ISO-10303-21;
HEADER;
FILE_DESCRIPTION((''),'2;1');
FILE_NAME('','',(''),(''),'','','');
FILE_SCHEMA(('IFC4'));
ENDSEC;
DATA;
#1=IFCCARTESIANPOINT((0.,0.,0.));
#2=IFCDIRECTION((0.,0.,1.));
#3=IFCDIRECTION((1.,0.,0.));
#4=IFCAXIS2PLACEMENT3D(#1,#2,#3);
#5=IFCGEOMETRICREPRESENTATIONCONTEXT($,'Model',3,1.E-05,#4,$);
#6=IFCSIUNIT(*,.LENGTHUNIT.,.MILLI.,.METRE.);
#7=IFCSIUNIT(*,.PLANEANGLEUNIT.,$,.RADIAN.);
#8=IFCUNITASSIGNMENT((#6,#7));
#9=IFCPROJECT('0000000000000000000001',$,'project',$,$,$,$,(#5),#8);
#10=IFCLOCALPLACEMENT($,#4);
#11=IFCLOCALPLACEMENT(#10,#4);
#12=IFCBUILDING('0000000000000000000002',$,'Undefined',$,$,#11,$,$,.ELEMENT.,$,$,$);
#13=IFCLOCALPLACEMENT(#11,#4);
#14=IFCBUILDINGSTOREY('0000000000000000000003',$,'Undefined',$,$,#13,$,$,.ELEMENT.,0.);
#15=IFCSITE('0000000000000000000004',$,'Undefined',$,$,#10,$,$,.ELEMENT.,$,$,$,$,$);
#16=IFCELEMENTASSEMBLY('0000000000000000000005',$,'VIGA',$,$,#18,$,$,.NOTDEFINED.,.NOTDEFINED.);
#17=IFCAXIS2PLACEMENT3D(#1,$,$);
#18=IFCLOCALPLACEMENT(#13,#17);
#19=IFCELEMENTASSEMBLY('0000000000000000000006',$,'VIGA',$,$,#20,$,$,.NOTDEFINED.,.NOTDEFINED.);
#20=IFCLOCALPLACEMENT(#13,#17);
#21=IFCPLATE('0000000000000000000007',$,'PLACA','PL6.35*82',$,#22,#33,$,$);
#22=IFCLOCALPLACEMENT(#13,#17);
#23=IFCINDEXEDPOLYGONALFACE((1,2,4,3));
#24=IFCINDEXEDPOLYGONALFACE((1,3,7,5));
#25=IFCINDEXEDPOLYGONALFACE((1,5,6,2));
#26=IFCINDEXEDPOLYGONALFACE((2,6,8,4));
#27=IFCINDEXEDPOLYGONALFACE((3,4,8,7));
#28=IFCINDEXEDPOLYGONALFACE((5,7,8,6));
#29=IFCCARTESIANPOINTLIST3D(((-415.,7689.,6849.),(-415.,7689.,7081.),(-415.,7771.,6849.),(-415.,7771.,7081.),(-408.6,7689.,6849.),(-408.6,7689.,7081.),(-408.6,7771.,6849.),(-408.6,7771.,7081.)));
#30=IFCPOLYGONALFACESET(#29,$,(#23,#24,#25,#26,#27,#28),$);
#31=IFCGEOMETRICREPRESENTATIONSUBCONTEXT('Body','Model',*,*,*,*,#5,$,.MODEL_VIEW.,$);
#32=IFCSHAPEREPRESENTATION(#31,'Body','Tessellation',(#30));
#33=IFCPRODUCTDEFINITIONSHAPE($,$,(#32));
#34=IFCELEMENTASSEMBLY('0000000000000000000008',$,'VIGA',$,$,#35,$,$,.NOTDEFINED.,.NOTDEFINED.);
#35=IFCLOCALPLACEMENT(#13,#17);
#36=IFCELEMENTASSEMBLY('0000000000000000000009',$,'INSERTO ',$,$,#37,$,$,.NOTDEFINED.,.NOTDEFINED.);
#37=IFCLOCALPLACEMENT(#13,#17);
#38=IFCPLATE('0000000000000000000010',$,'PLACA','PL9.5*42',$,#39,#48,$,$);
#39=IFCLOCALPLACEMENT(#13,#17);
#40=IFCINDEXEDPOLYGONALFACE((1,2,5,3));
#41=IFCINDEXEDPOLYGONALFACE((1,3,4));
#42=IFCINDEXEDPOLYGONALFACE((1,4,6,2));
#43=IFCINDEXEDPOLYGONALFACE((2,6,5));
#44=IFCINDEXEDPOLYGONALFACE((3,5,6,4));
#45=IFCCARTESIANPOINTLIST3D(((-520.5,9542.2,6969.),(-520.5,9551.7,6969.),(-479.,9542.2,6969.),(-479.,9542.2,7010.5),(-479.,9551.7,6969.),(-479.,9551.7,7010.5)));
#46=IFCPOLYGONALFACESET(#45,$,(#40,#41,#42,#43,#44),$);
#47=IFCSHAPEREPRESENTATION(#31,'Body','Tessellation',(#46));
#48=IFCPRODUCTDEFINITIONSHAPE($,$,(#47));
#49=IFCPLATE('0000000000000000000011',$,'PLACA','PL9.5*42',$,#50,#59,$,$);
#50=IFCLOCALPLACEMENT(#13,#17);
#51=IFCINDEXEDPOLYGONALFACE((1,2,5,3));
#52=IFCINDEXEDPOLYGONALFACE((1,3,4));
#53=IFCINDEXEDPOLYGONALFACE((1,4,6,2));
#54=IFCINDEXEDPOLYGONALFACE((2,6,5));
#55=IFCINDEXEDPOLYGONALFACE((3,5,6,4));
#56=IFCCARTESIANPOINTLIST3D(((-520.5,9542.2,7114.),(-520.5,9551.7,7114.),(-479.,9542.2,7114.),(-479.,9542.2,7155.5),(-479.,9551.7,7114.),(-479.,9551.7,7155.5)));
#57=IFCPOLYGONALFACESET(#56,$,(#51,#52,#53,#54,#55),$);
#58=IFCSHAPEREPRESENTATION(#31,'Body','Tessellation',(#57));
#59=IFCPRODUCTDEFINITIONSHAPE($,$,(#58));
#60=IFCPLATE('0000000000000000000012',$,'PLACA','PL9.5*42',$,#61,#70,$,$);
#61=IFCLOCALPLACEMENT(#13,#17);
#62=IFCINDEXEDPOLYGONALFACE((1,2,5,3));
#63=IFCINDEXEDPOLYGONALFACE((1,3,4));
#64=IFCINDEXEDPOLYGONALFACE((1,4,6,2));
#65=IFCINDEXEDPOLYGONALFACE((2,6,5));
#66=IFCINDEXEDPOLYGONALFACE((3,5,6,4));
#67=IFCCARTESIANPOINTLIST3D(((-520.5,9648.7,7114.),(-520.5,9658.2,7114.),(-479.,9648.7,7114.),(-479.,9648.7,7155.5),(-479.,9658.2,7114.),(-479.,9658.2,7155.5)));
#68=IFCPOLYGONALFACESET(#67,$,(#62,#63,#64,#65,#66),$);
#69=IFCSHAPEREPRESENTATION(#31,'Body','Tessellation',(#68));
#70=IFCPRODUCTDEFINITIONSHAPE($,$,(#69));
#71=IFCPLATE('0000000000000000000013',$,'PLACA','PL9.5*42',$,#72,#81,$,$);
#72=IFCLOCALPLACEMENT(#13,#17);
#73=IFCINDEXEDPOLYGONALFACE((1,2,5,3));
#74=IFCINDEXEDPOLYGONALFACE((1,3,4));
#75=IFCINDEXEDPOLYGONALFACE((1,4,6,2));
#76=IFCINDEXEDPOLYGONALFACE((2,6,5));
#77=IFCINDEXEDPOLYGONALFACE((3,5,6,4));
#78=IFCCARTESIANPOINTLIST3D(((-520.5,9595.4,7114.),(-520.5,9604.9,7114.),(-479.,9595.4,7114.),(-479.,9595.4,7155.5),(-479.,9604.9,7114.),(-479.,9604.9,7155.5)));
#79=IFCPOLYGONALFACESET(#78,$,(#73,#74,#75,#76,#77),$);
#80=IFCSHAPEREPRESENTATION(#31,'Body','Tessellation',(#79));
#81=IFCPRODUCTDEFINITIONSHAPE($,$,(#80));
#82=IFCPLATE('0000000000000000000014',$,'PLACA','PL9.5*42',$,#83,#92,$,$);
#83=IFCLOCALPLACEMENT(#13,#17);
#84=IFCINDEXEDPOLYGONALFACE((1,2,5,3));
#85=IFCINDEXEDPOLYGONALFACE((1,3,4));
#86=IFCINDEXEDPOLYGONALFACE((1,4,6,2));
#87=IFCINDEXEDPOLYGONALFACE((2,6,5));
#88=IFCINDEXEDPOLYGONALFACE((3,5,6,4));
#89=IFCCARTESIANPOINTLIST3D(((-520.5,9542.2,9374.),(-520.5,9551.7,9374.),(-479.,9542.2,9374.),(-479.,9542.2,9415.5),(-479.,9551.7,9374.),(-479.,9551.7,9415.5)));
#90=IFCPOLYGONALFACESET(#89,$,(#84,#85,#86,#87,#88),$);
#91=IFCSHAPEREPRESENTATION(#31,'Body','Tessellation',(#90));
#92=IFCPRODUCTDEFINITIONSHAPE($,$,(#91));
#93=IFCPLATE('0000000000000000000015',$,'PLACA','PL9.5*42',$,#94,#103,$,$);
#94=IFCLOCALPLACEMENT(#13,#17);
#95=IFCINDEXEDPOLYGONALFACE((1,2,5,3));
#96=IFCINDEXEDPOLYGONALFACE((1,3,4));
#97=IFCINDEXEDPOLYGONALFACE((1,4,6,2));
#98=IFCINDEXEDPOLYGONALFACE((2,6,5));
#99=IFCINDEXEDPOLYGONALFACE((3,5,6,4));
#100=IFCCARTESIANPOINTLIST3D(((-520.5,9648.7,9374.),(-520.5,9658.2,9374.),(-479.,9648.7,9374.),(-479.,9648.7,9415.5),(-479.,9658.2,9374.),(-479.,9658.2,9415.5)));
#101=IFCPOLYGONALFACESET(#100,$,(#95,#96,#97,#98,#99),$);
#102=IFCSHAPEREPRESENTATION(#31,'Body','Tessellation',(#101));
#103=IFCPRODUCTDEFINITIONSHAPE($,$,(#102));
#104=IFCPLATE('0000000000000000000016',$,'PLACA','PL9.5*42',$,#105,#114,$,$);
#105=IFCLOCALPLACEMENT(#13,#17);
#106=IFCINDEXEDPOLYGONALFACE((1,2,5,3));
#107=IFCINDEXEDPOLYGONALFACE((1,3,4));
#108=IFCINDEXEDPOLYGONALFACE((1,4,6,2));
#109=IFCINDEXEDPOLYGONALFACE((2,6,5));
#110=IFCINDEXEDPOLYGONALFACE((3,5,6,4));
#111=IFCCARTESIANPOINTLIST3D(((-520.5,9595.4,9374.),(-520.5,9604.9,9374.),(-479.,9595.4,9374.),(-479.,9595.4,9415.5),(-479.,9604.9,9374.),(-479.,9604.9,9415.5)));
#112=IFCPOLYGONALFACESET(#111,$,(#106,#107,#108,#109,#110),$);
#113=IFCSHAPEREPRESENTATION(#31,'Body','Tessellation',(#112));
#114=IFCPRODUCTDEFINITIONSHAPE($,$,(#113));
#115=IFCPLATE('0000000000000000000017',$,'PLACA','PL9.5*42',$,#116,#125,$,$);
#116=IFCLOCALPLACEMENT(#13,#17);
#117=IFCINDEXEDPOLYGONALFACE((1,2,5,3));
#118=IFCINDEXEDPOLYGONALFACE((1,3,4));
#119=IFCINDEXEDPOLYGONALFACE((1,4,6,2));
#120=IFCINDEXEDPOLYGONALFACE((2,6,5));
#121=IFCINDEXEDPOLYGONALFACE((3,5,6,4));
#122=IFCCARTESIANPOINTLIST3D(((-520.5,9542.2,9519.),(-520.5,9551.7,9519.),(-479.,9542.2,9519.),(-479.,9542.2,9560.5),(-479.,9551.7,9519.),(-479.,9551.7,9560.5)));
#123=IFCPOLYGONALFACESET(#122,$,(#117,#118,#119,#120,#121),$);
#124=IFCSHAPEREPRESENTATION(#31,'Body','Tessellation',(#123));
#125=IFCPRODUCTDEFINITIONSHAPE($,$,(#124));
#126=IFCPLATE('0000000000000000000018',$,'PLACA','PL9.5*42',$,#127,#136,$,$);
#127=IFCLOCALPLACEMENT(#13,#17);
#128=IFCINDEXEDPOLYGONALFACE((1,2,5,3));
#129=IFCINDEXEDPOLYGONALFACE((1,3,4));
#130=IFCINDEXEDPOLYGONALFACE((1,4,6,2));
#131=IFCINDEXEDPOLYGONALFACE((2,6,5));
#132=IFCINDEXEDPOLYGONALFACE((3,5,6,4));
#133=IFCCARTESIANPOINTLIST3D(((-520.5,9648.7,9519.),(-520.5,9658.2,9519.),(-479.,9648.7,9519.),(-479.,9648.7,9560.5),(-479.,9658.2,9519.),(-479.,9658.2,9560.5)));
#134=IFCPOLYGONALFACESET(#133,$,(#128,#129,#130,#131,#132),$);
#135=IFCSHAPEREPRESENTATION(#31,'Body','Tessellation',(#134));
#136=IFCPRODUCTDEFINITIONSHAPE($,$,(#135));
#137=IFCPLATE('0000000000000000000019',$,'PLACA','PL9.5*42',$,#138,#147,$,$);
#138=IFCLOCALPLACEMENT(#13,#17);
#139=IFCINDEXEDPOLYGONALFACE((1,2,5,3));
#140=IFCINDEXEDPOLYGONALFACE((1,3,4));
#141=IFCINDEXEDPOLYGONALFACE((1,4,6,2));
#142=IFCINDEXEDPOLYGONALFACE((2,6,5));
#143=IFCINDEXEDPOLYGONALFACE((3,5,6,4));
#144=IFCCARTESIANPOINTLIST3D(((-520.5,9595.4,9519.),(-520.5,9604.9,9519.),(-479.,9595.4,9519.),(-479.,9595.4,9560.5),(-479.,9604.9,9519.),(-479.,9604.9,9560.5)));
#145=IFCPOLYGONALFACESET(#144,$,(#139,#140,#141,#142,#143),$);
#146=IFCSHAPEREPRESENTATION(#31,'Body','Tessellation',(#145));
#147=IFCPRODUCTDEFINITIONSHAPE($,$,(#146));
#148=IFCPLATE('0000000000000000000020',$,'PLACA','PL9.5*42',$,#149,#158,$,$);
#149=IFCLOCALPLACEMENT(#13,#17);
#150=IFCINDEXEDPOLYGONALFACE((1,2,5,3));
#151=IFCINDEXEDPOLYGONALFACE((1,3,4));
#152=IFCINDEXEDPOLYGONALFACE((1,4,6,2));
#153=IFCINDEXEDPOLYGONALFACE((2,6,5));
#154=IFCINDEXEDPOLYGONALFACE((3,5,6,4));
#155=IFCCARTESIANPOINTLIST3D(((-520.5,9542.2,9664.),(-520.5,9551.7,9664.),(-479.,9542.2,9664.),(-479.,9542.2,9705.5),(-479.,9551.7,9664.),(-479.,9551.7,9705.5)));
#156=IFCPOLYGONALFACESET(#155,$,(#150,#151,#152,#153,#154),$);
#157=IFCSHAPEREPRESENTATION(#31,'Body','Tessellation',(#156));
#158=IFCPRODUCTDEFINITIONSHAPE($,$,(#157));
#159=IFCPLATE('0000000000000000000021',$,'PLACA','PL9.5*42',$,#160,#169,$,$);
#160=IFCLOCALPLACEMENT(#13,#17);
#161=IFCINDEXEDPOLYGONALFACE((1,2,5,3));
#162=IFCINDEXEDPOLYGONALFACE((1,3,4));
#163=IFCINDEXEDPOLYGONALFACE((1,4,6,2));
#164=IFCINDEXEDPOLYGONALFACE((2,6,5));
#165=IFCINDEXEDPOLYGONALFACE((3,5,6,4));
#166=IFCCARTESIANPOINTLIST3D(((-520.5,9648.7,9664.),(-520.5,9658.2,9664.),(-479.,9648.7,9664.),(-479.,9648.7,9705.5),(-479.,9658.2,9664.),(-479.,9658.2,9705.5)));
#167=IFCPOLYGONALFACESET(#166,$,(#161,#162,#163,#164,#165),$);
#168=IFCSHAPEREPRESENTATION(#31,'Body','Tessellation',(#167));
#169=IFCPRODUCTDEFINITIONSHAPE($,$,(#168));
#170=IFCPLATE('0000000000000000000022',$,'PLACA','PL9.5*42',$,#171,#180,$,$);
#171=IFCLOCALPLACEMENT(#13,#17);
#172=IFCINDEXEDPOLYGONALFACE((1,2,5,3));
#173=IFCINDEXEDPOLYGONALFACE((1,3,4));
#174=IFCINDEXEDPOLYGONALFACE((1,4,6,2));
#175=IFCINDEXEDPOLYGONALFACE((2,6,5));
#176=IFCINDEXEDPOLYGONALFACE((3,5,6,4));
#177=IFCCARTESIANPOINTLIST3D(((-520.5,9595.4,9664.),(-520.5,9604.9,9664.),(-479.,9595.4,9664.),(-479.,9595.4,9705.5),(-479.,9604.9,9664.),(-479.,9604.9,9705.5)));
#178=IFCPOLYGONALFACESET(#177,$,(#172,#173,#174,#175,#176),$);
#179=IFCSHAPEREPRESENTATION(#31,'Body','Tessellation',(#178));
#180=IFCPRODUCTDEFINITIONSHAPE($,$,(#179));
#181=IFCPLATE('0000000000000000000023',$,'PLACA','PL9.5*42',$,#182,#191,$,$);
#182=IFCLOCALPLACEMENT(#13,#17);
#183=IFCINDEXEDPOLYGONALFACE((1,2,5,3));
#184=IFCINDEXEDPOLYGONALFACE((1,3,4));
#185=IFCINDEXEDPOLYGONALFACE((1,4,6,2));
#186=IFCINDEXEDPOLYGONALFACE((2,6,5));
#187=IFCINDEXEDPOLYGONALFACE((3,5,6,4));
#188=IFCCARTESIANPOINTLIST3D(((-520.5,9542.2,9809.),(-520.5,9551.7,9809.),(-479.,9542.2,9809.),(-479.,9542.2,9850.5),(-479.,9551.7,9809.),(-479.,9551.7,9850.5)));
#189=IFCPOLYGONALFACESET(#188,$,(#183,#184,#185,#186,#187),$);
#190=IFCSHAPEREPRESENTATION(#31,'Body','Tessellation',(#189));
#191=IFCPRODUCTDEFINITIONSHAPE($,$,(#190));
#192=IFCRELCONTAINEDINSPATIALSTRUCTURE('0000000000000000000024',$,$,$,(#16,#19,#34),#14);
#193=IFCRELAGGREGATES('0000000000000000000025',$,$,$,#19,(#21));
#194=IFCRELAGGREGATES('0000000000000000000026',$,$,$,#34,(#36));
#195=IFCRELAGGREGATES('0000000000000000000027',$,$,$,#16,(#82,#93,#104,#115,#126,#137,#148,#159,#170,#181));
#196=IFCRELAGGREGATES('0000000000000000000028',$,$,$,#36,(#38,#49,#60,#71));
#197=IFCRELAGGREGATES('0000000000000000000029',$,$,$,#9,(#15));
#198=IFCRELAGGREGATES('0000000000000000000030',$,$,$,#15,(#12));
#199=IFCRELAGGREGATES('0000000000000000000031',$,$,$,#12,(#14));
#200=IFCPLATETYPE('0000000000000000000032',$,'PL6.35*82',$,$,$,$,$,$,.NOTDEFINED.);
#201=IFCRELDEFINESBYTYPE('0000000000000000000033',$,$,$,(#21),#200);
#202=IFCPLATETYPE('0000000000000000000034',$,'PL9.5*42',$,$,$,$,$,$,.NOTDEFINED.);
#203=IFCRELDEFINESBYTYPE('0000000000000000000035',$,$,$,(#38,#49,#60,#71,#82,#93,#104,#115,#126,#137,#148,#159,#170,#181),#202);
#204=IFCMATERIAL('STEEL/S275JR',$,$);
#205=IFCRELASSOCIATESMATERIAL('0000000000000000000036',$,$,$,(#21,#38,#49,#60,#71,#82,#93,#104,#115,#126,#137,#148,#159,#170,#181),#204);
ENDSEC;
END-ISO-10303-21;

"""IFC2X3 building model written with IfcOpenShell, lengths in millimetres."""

from ifc_helpers import new_model, si_unit, frame, origin_with_axes, place, context, subcontext, project, spatial, polyline, outline, extrude, material, type_object, element, aggregate, save


model = new_model("IFC2X3")

# Units and contexts
model_context = context("Model", 3, precision=1e-05, world=origin_with_axes())
body_context = subcontext(model_context, "Body", "Model", "MODEL_VIEW")
ifc_project = project(units=[si_unit("LENGTHUNIT", "METRE", prefix="MILLI"), si_unit("PLANEANGLEUNIT", "RADIAN")], contexts=[model_context])

# Site, building, storey
site_placement = place(None, origin_with_axes())
site = spatial("IfcSite", under=ifc_project, at=site_placement, Name="Undefined", CompositionType="ELEMENT")
building_placement = place(site_placement, origin_with_axes())
building = spatial("IfcBuilding", under=site, at=building_placement, Name="Undefined", CompositionType="ELEMENT")
storey_placement = place(building_placement, origin_with_axes())
storey = spatial("IfcBuildingStorey", under=building, at=storey_placement, Name="Undefined", CompositionType="ELEMENT", Elevation=0.0)

# Shared definitions
ifc_material_1 = material(Name="STEEL/S275JR")

# Element assemblies, plate
assembly_1_placement = place(storey_placement, origin_with_axes())
assembly_1 = element("IfcElementAssembly", 1, at=assembly_1_placement, inside=storey, Name="VIGA", AssemblyPlace="NOTDEFINED", PredefinedType="NOTDEFINED")
assembly_2_placement = place(storey_placement, origin_with_axes())
assembly_2 = element("IfcElementAssembly", 2, at=assembly_2_placement, inside=storey, Name="VIGA", AssemblyPlace="NOTDEFINED", PredefinedType="NOTDEFINED")
plate_type_1 = type_object("IfcPlateType", Name="PL6.35*82", PredefinedType="NOTDEFINED")
plate_1_placement = place(assembly_2_placement, frame((-411.8, 7689.0, 7081.0), z_axis=(-1.0, 0.0, 0.0), x_axis=(0.0, 1.0, 0.0)))
plate_1 = element("IfcPlate", 3, at=plate_1_placement, type_object=plate_type_1, material=ifc_material_1, Name="PLACA", Description="PL6.35*82", context=body_context, shape_type="SweptSolid", body=[
    extrude(outline(polyline([(0.0, 0.0), (82.0, 0.0), (82.0, 232.0), (0.0, 232.0), (0.0, 0.0)])), frame((0.0, 0.0, -3.2), z_axis=(0.0, 0.0, 1.0), x_axis=(1.0, 0.0, 0.0)), (0.0, 0.0, 1.0), 6.4),
])
aggregate(assembly_2, [plate_1])

# Element assemblies, plates
assembly_3_placement = place(storey_placement, origin_with_axes())
assembly_3 = element("IfcElementAssembly", 4, at=assembly_3_placement, inside=storey, Name="VIGA", AssemblyPlace="NOTDEFINED", PredefinedType="NOTDEFINED")
assembly_4_placement = place(assembly_3_placement, origin_with_axes())
assembly_4 = element("IfcElementAssembly", 5, at=assembly_4_placement, Name="INSERTO ", AssemblyPlace="NOTDEFINED", PredefinedType="NOTDEFINED")
aggregate(assembly_3, [assembly_4])
plate_type_2 = type_object("IfcPlateType", Name="PL9.5*42", PredefinedType="NOTDEFINED")
plate_2_placement = place(assembly_4_placement, frame((-479.0, 9546.9, 6969.0), z_axis=(0.0, -1.0, 0.0), x_axis=(0.0, 0.0, 1.0)))
plate_2 = element("IfcPlate", 6, at=plate_2_placement, type_object=plate_type_2, material=ifc_material_1, Name="PLACA", Description="PL9.5*42", context=body_context, shape_type="SweptSolid", body=[
    extrude(outline(polyline([(0.0, 0.0), (41.5, 0.0), (0.0, 41.5), (0.0, 0.0)])), frame((0.0, 0.0, -4.7), z_axis=(0.0, 0.0, 1.0), x_axis=(1.0, 0.0, 0.0)), (0.0, 0.0, 1.0), 9.5),
])
plate_3_placement = place(assembly_4_placement, frame((-479.0, 9547.0, 7114.0), z_axis=(0.0, -1.0, 0.0), x_axis=(0.0, 0.0, 1.0)))
plate_3 = element("IfcPlate", 7, at=plate_3_placement, type_object=plate_type_2, material=ifc_material_1, Name="PLACA", Description="PL9.5*42", context=body_context, shape_type="SweptSolid", body=[
    extrude(outline(polyline([(0.0, 0.0), (41.5, 0.0), (0.0, 41.5), (0.0, 0.0)])), frame((0.0, 0.0, -4.7), z_axis=(0.0, 0.0, 1.0), x_axis=(1.0, 0.0, 0.0)), (0.0, 0.0, 1.0), 9.5),
])
plate_4_placement = place(assembly_4_placement, frame((-479.0, 9653.4, 7114.0), z_axis=(0.0, -1.0, 0.0), x_axis=(0.0, 0.0, 1.0)))
plate_4 = element("IfcPlate", 8, at=plate_4_placement, type_object=plate_type_2, material=ifc_material_1, Name="PLACA", Description="PL9.5*42", context=body_context, shape_type="SweptSolid", body=[
    extrude(outline(polyline([(0.0, 0.0), (41.5, 0.0), (0.0, 41.5), (0.0, 0.0)])), frame((0.0, 0.0, -4.7), z_axis=(0.0, 0.0, 1.0), x_axis=(1.0, 0.0, 0.0)), (0.0, 0.0, 1.0), 9.5),
])
plate_5_placement = place(assembly_4_placement, frame((-479.0, 9600.2, 7114.0), z_axis=(0.0, -1.0, 0.0), x_axis=(0.0, 0.0, 1.0)))
plate_5 = element("IfcPlate", 9, at=plate_5_placement, type_object=plate_type_2, material=ifc_material_1, Name="PLACA", Description="PL9.5*42", context=body_context, shape_type="SweptSolid", body=[
    extrude(outline(polyline([(0.0, 0.0), (41.5, 0.0), (0.0, 41.5), (0.0, 0.0)])), frame((0.0, 0.0, -4.7), z_axis=(0.0, 0.0, 1.0), x_axis=(1.0, 0.0, 0.0)), (0.0, 0.0, 1.0), 9.5),
])

# Plates
plate_6_placement = place(assembly_1_placement, frame((-479.0, 9547.0, 9374.0), z_axis=(0.0, -1.0, 0.0), x_axis=(0.0, 0.0, 1.0)))
plate_6 = element("IfcPlate", 10, at=plate_6_placement, type_object=plate_type_2, material=ifc_material_1, Name="PLACA", Description="PL9.5*42", context=body_context, shape_type="SweptSolid", body=[
    extrude(outline(polyline([(0.0, 0.0), (41.5, 0.0), (0.0, 41.5), (0.0, 0.0)])), frame((0.0, 0.0, -4.7), z_axis=(0.0, 0.0, 1.0), x_axis=(1.0, 0.0, 0.0)), (0.0, 0.0, 1.0), 9.5),
])
plate_7_placement = place(assembly_1_placement, frame((-479.0, 9653.4, 9374.0), z_axis=(0.0, -1.0, 0.0), x_axis=(0.0, 0.0, 1.0)))
plate_7 = element("IfcPlate", 11, at=plate_7_placement, type_object=plate_type_2, material=ifc_material_1, Name="PLACA", Description="PL9.5*42", context=body_context, shape_type="SweptSolid", body=[
    extrude(outline(polyline([(0.0, 0.0), (41.5, 0.0), (0.0, 41.5), (0.0, 0.0)])), frame((0.0, 0.0, -4.7), z_axis=(0.0, 0.0, 1.0), x_axis=(1.0, 0.0, 0.0)), (0.0, 0.0, 1.0), 9.5),
])
plate_8_placement = place(assembly_1_placement, frame((-479.0, 9600.2, 9374.0), z_axis=(0.0, -1.0, 0.0), x_axis=(0.0, 0.0, 1.0)))
plate_8 = element("IfcPlate", 12, at=plate_8_placement, type_object=plate_type_2, material=ifc_material_1, Name="PLACA", Description="PL9.5*42", context=body_context, shape_type="SweptSolid", body=[
    extrude(outline(polyline([(0.0, 0.0), (41.5, 0.0), (0.0, 41.5), (0.0, 0.0)])), frame((0.0, 0.0, -4.7), z_axis=(0.0, 0.0, 1.0), x_axis=(1.0, 0.0, 0.0)), (0.0, 0.0, 1.0), 9.5),
])
plate_9_placement = place(assembly_1_placement, frame((-479.0, 9547.0, 9519.0), z_axis=(0.0, -1.0, 0.0), x_axis=(0.0, 0.0, 1.0)))
plate_9 = element("IfcPlate", 13, at=plate_9_placement, type_object=plate_type_2, material=ifc_material_1, Name="PLACA", Description="PL9.5*42", context=body_context, shape_type="SweptSolid", body=[
    extrude(outline(polyline([(0.0, 0.0), (41.5, 0.0), (0.0, 41.5), (0.0, 0.0)])), frame((0.0, 0.0, -4.7), z_axis=(0.0, 0.0, 1.0), x_axis=(1.0, 0.0, 0.0)), (0.0, 0.0, 1.0), 9.5),
])
plate_10_placement = place(assembly_1_placement, frame((-479.0, 9653.4, 9519.0), z_axis=(0.0, -1.0, 0.0), x_axis=(0.0, 0.0, 1.0)))
plate_10 = element("IfcPlate", 14, at=plate_10_placement, type_object=plate_type_2, material=ifc_material_1, Name="PLACA", Description="PL9.5*42", context=body_context, shape_type="SweptSolid", body=[
    extrude(outline(polyline([(0.0, 0.0), (41.5, 0.0), (0.0, 41.5), (0.0, 0.0)])), frame((0.0, 0.0, -4.7), z_axis=(0.0, 0.0, 1.0), x_axis=(1.0, 0.0, 0.0)), (0.0, 0.0, 1.0), 9.5),
])
plate_11_placement = place(assembly_1_placement, frame((-479.0, 9600.2, 9519.0), z_axis=(0.0, -1.0, 0.0), x_axis=(0.0, 0.0, 1.0)))
plate_11 = element("IfcPlate", 15, at=plate_11_placement, type_object=plate_type_2, material=ifc_material_1, Name="PLACA", Description="PL9.5*42", context=body_context, shape_type="SweptSolid", body=[
    extrude(outline(polyline([(0.0, 0.0), (41.5, 0.0), (0.0, 41.5), (0.0, 0.0)])), frame((0.0, 0.0, -4.7), z_axis=(0.0, 0.0, 1.0), x_axis=(1.0, 0.0, 0.0)), (0.0, 0.0, 1.0), 9.5),
])
plate_12_placement = place(assembly_1_placement, frame((-479.0, 9547.0, 9664.0), z_axis=(0.0, -1.0, 0.0), x_axis=(0.0, 0.0, 1.0)))
plate_12 = element("IfcPlate", 16, at=plate_12_placement, type_object=plate_type_2, material=ifc_material_1, Name="PLACA", Description="PL9.5*42", context=body_context, shape_type="SweptSolid", body=[
    extrude(outline(polyline([(0.0, 0.0), (41.5, 0.0), (0.0, 41.5), (0.0, 0.0)])), frame((0.0, 0.0, -4.7), z_axis=(0.0, 0.0, 1.0), x_axis=(1.0, 0.0, 0.0)), (0.0, 0.0, 1.0), 9.5),
])
plate_13_placement = place(assembly_1_placement, frame((-479.0, 9653.4, 9664.0), z_axis=(0.0, -1.0, 0.0), x_axis=(0.0, 0.0, 1.0)))
plate_13 = element("IfcPlate", 17, at=plate_13_placement, type_object=plate_type_2, material=ifc_material_1, Name="PLACA", Description="PL9.5*42", context=body_context, shape_type="SweptSolid", body=[
    extrude(outline(polyline([(0.0, 0.0), (41.5, 0.0), (0.0, 41.5), (0.0, 0.0)])), frame((0.0, 0.0, -4.7), z_axis=(0.0, 0.0, 1.0), x_axis=(1.0, 0.0, 0.0)), (0.0, 0.0, 1.0), 9.5),
])
plate_14_placement = place(assembly_1_placement, frame((-479.0, 9600.2, 9664.0), z_axis=(0.0, -1.0, 0.0), x_axis=(0.0, 0.0, 1.0)))
plate_14 = element("IfcPlate", 18, at=plate_14_placement, type_object=plate_type_2, material=ifc_material_1, Name="PLACA", Description="PL9.5*42", context=body_context, shape_type="SweptSolid", body=[
    extrude(outline(polyline([(0.0, 0.0), (41.5, 0.0), (0.0, 41.5), (0.0, 0.0)])), frame((0.0, 0.0, -4.7), z_axis=(0.0, 0.0, 1.0), x_axis=(1.0, 0.0, 0.0)), (0.0, 0.0, 1.0), 9.5),
])
plate_15_placement = place(assembly_1_placement, frame((-479.0, 9546.9, 9809.0), z_axis=(0.0, -1.0, 0.0), x_axis=(0.0, 0.0, 1.0)))
plate_15 = element("IfcPlate", 19, at=plate_15_placement, type_object=plate_type_2, material=ifc_material_1, Name="PLACA", Description="PL9.5*42", context=body_context, shape_type="SweptSolid", body=[
    extrude(outline(polyline([(0.0, 0.0), (41.5, 0.0), (0.0, 41.5), (0.0, 0.0)])), frame((0.0, 0.0, -4.7), z_axis=(0.0, 0.0, 1.0), x_axis=(1.0, 0.0, 0.0)), (0.0, 0.0, 1.0), 9.5),
])
aggregate(assembly_1, [plate_6, plate_7, plate_8, plate_9, plate_10, plate_11, plate_12, plate_13, plate_14, plate_15])
aggregate(assembly_4, [plate_2, plate_3, plate_4, plate_5])

save(model, "model.ifc")
